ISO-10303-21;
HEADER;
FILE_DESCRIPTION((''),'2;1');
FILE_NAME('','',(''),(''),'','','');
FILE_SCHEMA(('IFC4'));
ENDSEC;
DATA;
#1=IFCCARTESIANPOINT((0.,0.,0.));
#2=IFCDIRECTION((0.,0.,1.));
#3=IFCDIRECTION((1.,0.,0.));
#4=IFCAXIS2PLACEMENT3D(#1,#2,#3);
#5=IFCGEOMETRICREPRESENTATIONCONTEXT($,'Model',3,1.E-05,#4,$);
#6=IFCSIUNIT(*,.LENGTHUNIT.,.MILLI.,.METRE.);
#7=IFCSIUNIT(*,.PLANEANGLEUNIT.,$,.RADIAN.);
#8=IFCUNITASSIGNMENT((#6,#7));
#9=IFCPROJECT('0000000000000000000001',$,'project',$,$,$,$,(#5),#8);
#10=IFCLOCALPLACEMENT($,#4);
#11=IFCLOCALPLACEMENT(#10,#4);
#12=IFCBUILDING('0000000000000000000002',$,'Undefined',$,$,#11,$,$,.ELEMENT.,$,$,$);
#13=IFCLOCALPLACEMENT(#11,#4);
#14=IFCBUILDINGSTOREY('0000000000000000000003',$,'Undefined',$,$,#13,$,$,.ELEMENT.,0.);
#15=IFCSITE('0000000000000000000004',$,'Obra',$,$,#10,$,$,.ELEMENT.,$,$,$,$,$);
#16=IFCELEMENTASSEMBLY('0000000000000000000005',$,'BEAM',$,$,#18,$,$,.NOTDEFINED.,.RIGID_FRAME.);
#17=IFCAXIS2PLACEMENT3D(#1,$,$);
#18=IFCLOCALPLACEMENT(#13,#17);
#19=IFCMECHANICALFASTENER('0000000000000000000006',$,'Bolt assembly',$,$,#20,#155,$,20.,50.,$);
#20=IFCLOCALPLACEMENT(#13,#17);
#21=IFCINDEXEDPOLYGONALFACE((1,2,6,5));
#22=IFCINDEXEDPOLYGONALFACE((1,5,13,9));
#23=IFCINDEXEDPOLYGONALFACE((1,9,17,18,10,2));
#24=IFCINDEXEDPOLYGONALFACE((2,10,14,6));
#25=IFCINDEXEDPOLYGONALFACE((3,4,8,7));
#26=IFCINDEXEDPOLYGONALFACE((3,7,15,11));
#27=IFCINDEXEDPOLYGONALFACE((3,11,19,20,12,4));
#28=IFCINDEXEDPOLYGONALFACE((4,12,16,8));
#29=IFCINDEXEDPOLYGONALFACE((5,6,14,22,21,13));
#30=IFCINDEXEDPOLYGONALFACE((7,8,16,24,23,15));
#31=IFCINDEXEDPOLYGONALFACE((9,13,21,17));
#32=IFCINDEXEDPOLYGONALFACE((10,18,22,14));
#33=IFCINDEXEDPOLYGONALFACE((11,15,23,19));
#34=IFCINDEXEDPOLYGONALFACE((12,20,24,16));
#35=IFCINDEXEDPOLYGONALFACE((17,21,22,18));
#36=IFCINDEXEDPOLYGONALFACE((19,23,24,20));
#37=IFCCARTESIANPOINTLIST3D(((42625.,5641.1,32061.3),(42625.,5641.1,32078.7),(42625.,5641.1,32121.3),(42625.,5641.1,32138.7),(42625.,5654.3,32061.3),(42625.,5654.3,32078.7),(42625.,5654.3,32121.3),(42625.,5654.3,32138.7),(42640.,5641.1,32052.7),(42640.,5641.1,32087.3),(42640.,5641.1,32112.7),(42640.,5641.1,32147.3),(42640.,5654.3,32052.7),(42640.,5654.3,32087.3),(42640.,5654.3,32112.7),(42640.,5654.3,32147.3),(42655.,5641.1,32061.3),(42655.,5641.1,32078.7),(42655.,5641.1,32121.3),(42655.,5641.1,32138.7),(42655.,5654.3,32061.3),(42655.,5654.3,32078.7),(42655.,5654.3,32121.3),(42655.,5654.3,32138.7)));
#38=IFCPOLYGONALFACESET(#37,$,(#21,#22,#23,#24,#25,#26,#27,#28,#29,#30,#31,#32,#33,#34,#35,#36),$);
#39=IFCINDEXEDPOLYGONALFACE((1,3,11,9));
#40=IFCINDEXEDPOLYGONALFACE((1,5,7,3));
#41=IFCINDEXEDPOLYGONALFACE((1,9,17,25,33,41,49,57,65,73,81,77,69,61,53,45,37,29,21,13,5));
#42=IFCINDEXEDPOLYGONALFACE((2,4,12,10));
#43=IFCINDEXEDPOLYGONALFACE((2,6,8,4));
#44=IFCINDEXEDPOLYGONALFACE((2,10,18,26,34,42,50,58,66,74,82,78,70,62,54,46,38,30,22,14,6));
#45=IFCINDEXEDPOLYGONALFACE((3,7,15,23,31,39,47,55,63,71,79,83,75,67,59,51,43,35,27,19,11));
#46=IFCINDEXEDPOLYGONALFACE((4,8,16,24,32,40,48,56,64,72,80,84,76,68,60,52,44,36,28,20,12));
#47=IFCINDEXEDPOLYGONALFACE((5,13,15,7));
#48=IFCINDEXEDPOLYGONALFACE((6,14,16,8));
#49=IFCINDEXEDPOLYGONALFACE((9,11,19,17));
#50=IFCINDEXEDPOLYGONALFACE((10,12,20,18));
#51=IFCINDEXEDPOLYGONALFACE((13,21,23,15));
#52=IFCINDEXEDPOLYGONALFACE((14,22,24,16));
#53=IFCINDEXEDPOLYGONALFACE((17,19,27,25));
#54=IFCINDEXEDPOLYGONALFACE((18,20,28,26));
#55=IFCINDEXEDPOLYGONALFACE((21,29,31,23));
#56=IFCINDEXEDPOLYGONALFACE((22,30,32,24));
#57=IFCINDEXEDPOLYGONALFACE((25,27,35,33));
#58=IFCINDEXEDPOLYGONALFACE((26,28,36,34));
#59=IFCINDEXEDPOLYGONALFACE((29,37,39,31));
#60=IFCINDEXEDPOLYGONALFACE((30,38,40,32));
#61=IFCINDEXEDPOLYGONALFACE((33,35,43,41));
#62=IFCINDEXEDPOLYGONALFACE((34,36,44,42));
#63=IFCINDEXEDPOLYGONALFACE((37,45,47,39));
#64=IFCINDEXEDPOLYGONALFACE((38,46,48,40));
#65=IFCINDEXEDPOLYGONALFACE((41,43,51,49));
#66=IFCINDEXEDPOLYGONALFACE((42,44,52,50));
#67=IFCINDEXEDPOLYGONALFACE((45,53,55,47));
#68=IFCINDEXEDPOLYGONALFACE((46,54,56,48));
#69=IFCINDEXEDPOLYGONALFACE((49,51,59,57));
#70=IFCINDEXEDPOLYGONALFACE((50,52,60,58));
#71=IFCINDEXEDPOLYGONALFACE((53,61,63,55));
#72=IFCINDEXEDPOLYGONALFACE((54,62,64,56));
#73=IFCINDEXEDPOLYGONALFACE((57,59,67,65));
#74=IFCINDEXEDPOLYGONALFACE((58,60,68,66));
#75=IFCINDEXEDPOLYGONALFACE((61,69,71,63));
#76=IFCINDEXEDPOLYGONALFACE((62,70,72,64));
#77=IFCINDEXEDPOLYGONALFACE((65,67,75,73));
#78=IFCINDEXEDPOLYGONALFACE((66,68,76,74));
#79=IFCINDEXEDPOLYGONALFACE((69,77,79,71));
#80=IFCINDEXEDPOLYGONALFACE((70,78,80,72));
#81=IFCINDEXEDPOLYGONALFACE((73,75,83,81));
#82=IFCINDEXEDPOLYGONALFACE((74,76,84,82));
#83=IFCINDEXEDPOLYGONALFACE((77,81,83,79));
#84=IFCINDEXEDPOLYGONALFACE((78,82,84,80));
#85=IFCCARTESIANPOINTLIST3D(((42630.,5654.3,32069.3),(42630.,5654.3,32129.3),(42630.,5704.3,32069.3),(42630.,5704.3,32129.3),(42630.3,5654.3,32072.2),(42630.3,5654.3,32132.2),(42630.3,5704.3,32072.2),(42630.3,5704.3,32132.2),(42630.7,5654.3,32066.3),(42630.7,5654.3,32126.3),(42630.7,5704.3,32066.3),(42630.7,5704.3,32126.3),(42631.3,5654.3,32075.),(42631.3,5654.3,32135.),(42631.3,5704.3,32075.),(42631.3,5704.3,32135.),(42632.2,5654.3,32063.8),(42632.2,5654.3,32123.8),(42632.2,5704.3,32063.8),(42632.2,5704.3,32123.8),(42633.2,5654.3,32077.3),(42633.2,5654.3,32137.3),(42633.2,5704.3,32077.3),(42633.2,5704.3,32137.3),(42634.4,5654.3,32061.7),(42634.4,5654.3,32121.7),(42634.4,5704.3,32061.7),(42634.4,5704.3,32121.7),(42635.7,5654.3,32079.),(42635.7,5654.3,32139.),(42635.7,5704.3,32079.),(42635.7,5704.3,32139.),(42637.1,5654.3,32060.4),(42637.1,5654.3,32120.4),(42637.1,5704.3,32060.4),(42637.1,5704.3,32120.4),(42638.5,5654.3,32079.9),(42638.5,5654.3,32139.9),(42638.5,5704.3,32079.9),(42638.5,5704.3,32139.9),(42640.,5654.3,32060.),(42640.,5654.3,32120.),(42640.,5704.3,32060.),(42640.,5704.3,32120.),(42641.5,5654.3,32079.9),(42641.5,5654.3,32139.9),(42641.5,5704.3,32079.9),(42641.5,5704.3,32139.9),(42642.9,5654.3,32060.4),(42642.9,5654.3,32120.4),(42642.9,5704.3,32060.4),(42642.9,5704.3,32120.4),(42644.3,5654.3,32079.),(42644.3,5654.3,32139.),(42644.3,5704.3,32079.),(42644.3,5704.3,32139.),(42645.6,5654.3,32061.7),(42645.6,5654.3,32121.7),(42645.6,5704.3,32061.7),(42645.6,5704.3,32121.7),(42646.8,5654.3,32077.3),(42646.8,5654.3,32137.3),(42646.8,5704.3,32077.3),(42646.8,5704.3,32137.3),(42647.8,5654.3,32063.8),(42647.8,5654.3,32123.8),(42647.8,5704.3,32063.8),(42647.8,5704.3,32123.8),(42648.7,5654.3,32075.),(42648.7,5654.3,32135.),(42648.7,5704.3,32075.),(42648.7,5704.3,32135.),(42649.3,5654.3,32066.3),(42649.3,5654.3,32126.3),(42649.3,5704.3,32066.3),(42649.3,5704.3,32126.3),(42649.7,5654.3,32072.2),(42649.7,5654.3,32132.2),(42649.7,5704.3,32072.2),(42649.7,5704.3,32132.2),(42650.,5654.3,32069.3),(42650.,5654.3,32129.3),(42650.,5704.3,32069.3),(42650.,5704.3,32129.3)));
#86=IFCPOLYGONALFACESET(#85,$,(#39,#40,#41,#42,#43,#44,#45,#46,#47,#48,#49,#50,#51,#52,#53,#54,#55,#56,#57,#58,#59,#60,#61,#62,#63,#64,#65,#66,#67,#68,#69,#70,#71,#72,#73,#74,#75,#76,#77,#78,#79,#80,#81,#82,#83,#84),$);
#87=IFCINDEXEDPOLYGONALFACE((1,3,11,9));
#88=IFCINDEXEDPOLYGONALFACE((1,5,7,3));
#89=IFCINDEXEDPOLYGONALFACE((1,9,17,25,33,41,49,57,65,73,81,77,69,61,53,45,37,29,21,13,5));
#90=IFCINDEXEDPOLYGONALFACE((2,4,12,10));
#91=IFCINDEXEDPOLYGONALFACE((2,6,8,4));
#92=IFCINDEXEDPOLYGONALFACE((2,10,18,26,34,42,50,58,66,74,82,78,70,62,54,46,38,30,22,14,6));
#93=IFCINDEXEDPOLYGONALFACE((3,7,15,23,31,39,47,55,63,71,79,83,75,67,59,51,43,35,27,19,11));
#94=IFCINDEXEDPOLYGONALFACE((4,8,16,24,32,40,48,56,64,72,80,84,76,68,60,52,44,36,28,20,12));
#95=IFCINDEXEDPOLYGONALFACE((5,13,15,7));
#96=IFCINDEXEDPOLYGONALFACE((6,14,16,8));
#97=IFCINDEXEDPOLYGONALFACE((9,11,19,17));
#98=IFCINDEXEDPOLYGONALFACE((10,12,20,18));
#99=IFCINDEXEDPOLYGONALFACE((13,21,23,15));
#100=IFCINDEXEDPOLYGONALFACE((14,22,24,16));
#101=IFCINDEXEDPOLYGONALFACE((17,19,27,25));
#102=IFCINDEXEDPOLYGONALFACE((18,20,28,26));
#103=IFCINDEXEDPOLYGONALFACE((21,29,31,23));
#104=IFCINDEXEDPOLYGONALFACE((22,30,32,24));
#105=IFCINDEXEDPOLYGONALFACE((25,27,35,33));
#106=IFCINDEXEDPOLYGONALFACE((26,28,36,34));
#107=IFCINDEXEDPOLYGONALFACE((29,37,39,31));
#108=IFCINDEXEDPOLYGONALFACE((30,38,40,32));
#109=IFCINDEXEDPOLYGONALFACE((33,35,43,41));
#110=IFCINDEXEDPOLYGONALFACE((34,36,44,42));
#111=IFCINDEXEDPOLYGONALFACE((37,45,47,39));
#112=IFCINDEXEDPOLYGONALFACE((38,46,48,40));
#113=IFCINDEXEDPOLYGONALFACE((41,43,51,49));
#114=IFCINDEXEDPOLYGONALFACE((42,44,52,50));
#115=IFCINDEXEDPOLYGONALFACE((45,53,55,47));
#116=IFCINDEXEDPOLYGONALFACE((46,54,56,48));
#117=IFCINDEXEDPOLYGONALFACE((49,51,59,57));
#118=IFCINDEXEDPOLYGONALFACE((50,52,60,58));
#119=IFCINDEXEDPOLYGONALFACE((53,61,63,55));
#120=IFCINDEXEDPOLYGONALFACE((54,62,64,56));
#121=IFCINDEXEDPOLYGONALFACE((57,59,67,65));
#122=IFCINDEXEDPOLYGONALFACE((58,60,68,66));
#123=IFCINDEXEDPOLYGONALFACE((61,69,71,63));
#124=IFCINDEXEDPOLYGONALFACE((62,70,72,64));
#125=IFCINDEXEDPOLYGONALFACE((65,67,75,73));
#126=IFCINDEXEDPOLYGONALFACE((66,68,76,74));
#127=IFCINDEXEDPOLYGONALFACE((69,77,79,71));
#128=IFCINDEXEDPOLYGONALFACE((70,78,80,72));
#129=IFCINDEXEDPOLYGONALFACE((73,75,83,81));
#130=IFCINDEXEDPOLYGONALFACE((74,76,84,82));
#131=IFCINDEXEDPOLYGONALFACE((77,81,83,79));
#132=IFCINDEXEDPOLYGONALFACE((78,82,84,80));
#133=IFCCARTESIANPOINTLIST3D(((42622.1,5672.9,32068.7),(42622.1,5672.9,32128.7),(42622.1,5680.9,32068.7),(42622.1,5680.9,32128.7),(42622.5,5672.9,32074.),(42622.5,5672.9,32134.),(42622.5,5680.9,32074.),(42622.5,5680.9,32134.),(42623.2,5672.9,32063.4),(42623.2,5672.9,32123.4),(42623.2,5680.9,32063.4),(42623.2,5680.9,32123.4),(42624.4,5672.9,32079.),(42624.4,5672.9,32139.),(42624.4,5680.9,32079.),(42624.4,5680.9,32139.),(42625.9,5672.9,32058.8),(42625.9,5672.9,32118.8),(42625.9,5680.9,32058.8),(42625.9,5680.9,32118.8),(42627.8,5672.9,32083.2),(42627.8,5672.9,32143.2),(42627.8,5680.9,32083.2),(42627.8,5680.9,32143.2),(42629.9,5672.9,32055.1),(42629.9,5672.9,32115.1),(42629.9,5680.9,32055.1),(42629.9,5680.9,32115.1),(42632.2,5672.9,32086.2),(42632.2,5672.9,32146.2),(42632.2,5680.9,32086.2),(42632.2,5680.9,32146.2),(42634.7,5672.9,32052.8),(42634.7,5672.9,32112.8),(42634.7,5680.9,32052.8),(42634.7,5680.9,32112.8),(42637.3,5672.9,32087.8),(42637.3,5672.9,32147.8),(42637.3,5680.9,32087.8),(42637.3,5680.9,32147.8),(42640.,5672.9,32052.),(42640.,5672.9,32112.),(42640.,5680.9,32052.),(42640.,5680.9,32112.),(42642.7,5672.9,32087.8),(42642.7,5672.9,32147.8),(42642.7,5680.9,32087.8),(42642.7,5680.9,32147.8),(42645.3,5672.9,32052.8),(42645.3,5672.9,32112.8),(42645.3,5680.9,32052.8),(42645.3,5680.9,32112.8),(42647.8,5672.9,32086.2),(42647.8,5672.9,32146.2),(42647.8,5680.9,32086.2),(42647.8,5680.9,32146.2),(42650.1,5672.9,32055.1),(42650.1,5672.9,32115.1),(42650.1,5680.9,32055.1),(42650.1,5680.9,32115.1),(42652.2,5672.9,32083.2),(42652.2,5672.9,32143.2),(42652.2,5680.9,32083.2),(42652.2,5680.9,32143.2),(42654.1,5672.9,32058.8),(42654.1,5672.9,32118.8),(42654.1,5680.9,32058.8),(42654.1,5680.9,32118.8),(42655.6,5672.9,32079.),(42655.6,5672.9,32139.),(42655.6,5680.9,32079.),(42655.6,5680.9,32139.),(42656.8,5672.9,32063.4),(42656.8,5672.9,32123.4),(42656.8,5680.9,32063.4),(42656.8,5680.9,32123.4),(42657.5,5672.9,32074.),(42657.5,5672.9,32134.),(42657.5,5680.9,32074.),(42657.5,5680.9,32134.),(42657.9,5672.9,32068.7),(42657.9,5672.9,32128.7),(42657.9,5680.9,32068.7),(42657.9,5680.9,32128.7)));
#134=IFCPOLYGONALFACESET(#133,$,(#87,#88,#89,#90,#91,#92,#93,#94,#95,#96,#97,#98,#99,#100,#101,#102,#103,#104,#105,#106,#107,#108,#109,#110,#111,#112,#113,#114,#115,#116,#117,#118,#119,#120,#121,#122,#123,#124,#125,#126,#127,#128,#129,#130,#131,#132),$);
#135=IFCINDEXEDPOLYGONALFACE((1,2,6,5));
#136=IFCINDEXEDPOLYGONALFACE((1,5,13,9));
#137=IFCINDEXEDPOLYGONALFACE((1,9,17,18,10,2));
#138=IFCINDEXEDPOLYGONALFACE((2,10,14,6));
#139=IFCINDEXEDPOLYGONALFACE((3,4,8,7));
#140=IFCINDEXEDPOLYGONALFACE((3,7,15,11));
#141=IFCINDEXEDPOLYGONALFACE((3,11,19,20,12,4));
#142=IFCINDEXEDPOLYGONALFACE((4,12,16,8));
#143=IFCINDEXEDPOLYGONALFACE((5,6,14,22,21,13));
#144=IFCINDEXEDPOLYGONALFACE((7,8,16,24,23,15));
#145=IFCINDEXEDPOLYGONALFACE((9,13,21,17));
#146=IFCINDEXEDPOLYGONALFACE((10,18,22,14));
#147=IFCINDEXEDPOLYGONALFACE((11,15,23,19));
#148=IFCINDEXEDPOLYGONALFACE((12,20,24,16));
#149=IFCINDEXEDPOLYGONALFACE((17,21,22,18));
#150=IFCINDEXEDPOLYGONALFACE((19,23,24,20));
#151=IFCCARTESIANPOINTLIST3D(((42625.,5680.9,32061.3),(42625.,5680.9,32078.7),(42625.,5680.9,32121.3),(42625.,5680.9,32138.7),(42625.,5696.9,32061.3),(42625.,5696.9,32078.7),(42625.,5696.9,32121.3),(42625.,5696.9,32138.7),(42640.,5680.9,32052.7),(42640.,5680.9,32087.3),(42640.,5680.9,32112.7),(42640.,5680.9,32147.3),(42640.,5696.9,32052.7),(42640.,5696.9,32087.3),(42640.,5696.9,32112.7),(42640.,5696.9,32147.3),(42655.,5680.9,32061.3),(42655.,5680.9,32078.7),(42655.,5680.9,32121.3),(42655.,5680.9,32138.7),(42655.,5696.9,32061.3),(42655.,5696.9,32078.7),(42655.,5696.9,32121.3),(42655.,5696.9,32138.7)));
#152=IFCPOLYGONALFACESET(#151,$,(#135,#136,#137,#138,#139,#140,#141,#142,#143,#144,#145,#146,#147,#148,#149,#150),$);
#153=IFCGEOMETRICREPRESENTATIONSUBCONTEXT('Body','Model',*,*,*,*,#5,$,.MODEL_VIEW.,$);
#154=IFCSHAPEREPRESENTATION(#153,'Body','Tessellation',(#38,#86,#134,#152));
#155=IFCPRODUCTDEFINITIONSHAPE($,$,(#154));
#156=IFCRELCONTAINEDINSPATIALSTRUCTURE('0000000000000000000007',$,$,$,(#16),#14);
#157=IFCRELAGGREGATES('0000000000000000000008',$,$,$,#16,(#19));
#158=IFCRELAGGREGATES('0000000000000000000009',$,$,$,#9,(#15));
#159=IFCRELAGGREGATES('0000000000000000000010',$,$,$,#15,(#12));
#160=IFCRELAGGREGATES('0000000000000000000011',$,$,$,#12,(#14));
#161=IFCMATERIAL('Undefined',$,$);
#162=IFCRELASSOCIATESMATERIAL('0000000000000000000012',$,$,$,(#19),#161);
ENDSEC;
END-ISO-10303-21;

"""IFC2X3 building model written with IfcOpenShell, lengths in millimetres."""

from ifc_helpers import new_model, si_unit, frame, origin_with_axes, origin_2d_with_axis, place, context, subcontext, project, spatial, polyline, circle, outline, extrude, source, transform, mapped, material, element, aggregate, save


model = new_model("IFC2X3")

# Units and contexts
model_context = context("Model", 3, precision=1e-05, world=origin_with_axes())
body_context = subcontext(model_context, "Body", "Model", "MODEL_VIEW")
ifc_project = project(units=[si_unit("LENGTHUNIT", "METRE", prefix="MILLI"), si_unit("PLANEANGLEUNIT", "RADIAN")], contexts=[model_context])

# Site, building, storey
site_placement = place(None, origin_with_axes())
site = spatial("IfcSite", under=ifc_project, at=site_placement, Name="Obra", CompositionType="ELEMENT")
building_placement = place(site_placement, origin_with_axes())
building = spatial("IfcBuilding", under=site, at=building_placement, Name="Undefined", CompositionType="ELEMENT")
storey_placement = place(building_placement, origin_with_axes())
storey = spatial("IfcBuildingStorey", under=building, at=storey_placement, Name="Undefined", CompositionType="ELEMENT", Elevation=0.0)

# Element assembly
assembly_1_placement = place(storey_placement, origin_with_axes())
assembly_1 = element("IfcElementAssembly", 1, at=assembly_1_placement, inside=storey, Name="BEAM", AssemblyPlace="NOTDEFINED", PredefinedType="RIGID_FRAME")

# Shared definitions
ifc_material_1 = material(Name="Undefined")
shared_shape_1 = source(origin_with_axes(), body_context, "Body", "SweptSolid", [
    extrude(outline(polyline([(17.3, 0.0), (8.7, 15.0), (-8.7, 15.0), (-17.3, 0.0), (-8.7, -15.0), (8.7, -15.0), (17.3, 0.0)])), frame((0.0, -27.5, 0.0), z_axis=(0.0, 1.0, 0.0), x_axis=(1.0, 0.0, 0.0)), (0.0, 0.0, 1.0), 13.2),
    extrude(circle(Radius=10.0, at=origin_2d_with_axis()), frame((0.0, -14.3, 0.0), z_axis=(0.0, 1.0, 0.0), x_axis=(1.0, 0.0, 0.0)), (0.0, 0.0, 1.0), 50.0),
    extrude(circle(Radius=18.0, at=origin_2d_with_axis()), frame((0.0, 4.3, 0.0), z_axis=(0.0, 1.0, 0.0), x_axis=(1.0, 0.0, 0.0)), (0.0, 0.0, 1.0), 8.0),
    extrude(outline(polyline([(17.3, 0.0), (8.7, 15.0), (-8.7, 15.0), (-17.3, 0.0), (-8.7, -15.0), (8.7, -15.0), (17.3, 0.0)])), frame((0.0, 12.3, 0.0), z_axis=(0.0, 1.0, 0.0), x_axis=(1.0, 0.0, 0.0)), (0.0, 0.0, 1.0), 16.0),
])

# Mechanical fastener
mechanical_fastener_1_placement = place(assembly_1_placement, frame((42600.0, 5668.6, 32170.0), z_axis=(1.0, 0.0, 0.0), x_axis=(0.0, 0.0, -1.0)))
mechanical_fastener_1 = element("IfcMechanicalFastener", 2, at=mechanical_fastener_1_placement, material=ifc_material_1, Name="Bolt assembly", NominalDiameter=20.0, NominalLength=50.0, context=body_context, shape_type="MappedRepresentation", body=[
    mapped(shared_shape_1, transform((40.0, 0.0, 40.0))),
    mapped(shared_shape_1, transform((100.0, 0.0, 40.0))),
])

aggregate(assembly_1, [mechanical_fastener_1])

save(model, "model.ifc")
